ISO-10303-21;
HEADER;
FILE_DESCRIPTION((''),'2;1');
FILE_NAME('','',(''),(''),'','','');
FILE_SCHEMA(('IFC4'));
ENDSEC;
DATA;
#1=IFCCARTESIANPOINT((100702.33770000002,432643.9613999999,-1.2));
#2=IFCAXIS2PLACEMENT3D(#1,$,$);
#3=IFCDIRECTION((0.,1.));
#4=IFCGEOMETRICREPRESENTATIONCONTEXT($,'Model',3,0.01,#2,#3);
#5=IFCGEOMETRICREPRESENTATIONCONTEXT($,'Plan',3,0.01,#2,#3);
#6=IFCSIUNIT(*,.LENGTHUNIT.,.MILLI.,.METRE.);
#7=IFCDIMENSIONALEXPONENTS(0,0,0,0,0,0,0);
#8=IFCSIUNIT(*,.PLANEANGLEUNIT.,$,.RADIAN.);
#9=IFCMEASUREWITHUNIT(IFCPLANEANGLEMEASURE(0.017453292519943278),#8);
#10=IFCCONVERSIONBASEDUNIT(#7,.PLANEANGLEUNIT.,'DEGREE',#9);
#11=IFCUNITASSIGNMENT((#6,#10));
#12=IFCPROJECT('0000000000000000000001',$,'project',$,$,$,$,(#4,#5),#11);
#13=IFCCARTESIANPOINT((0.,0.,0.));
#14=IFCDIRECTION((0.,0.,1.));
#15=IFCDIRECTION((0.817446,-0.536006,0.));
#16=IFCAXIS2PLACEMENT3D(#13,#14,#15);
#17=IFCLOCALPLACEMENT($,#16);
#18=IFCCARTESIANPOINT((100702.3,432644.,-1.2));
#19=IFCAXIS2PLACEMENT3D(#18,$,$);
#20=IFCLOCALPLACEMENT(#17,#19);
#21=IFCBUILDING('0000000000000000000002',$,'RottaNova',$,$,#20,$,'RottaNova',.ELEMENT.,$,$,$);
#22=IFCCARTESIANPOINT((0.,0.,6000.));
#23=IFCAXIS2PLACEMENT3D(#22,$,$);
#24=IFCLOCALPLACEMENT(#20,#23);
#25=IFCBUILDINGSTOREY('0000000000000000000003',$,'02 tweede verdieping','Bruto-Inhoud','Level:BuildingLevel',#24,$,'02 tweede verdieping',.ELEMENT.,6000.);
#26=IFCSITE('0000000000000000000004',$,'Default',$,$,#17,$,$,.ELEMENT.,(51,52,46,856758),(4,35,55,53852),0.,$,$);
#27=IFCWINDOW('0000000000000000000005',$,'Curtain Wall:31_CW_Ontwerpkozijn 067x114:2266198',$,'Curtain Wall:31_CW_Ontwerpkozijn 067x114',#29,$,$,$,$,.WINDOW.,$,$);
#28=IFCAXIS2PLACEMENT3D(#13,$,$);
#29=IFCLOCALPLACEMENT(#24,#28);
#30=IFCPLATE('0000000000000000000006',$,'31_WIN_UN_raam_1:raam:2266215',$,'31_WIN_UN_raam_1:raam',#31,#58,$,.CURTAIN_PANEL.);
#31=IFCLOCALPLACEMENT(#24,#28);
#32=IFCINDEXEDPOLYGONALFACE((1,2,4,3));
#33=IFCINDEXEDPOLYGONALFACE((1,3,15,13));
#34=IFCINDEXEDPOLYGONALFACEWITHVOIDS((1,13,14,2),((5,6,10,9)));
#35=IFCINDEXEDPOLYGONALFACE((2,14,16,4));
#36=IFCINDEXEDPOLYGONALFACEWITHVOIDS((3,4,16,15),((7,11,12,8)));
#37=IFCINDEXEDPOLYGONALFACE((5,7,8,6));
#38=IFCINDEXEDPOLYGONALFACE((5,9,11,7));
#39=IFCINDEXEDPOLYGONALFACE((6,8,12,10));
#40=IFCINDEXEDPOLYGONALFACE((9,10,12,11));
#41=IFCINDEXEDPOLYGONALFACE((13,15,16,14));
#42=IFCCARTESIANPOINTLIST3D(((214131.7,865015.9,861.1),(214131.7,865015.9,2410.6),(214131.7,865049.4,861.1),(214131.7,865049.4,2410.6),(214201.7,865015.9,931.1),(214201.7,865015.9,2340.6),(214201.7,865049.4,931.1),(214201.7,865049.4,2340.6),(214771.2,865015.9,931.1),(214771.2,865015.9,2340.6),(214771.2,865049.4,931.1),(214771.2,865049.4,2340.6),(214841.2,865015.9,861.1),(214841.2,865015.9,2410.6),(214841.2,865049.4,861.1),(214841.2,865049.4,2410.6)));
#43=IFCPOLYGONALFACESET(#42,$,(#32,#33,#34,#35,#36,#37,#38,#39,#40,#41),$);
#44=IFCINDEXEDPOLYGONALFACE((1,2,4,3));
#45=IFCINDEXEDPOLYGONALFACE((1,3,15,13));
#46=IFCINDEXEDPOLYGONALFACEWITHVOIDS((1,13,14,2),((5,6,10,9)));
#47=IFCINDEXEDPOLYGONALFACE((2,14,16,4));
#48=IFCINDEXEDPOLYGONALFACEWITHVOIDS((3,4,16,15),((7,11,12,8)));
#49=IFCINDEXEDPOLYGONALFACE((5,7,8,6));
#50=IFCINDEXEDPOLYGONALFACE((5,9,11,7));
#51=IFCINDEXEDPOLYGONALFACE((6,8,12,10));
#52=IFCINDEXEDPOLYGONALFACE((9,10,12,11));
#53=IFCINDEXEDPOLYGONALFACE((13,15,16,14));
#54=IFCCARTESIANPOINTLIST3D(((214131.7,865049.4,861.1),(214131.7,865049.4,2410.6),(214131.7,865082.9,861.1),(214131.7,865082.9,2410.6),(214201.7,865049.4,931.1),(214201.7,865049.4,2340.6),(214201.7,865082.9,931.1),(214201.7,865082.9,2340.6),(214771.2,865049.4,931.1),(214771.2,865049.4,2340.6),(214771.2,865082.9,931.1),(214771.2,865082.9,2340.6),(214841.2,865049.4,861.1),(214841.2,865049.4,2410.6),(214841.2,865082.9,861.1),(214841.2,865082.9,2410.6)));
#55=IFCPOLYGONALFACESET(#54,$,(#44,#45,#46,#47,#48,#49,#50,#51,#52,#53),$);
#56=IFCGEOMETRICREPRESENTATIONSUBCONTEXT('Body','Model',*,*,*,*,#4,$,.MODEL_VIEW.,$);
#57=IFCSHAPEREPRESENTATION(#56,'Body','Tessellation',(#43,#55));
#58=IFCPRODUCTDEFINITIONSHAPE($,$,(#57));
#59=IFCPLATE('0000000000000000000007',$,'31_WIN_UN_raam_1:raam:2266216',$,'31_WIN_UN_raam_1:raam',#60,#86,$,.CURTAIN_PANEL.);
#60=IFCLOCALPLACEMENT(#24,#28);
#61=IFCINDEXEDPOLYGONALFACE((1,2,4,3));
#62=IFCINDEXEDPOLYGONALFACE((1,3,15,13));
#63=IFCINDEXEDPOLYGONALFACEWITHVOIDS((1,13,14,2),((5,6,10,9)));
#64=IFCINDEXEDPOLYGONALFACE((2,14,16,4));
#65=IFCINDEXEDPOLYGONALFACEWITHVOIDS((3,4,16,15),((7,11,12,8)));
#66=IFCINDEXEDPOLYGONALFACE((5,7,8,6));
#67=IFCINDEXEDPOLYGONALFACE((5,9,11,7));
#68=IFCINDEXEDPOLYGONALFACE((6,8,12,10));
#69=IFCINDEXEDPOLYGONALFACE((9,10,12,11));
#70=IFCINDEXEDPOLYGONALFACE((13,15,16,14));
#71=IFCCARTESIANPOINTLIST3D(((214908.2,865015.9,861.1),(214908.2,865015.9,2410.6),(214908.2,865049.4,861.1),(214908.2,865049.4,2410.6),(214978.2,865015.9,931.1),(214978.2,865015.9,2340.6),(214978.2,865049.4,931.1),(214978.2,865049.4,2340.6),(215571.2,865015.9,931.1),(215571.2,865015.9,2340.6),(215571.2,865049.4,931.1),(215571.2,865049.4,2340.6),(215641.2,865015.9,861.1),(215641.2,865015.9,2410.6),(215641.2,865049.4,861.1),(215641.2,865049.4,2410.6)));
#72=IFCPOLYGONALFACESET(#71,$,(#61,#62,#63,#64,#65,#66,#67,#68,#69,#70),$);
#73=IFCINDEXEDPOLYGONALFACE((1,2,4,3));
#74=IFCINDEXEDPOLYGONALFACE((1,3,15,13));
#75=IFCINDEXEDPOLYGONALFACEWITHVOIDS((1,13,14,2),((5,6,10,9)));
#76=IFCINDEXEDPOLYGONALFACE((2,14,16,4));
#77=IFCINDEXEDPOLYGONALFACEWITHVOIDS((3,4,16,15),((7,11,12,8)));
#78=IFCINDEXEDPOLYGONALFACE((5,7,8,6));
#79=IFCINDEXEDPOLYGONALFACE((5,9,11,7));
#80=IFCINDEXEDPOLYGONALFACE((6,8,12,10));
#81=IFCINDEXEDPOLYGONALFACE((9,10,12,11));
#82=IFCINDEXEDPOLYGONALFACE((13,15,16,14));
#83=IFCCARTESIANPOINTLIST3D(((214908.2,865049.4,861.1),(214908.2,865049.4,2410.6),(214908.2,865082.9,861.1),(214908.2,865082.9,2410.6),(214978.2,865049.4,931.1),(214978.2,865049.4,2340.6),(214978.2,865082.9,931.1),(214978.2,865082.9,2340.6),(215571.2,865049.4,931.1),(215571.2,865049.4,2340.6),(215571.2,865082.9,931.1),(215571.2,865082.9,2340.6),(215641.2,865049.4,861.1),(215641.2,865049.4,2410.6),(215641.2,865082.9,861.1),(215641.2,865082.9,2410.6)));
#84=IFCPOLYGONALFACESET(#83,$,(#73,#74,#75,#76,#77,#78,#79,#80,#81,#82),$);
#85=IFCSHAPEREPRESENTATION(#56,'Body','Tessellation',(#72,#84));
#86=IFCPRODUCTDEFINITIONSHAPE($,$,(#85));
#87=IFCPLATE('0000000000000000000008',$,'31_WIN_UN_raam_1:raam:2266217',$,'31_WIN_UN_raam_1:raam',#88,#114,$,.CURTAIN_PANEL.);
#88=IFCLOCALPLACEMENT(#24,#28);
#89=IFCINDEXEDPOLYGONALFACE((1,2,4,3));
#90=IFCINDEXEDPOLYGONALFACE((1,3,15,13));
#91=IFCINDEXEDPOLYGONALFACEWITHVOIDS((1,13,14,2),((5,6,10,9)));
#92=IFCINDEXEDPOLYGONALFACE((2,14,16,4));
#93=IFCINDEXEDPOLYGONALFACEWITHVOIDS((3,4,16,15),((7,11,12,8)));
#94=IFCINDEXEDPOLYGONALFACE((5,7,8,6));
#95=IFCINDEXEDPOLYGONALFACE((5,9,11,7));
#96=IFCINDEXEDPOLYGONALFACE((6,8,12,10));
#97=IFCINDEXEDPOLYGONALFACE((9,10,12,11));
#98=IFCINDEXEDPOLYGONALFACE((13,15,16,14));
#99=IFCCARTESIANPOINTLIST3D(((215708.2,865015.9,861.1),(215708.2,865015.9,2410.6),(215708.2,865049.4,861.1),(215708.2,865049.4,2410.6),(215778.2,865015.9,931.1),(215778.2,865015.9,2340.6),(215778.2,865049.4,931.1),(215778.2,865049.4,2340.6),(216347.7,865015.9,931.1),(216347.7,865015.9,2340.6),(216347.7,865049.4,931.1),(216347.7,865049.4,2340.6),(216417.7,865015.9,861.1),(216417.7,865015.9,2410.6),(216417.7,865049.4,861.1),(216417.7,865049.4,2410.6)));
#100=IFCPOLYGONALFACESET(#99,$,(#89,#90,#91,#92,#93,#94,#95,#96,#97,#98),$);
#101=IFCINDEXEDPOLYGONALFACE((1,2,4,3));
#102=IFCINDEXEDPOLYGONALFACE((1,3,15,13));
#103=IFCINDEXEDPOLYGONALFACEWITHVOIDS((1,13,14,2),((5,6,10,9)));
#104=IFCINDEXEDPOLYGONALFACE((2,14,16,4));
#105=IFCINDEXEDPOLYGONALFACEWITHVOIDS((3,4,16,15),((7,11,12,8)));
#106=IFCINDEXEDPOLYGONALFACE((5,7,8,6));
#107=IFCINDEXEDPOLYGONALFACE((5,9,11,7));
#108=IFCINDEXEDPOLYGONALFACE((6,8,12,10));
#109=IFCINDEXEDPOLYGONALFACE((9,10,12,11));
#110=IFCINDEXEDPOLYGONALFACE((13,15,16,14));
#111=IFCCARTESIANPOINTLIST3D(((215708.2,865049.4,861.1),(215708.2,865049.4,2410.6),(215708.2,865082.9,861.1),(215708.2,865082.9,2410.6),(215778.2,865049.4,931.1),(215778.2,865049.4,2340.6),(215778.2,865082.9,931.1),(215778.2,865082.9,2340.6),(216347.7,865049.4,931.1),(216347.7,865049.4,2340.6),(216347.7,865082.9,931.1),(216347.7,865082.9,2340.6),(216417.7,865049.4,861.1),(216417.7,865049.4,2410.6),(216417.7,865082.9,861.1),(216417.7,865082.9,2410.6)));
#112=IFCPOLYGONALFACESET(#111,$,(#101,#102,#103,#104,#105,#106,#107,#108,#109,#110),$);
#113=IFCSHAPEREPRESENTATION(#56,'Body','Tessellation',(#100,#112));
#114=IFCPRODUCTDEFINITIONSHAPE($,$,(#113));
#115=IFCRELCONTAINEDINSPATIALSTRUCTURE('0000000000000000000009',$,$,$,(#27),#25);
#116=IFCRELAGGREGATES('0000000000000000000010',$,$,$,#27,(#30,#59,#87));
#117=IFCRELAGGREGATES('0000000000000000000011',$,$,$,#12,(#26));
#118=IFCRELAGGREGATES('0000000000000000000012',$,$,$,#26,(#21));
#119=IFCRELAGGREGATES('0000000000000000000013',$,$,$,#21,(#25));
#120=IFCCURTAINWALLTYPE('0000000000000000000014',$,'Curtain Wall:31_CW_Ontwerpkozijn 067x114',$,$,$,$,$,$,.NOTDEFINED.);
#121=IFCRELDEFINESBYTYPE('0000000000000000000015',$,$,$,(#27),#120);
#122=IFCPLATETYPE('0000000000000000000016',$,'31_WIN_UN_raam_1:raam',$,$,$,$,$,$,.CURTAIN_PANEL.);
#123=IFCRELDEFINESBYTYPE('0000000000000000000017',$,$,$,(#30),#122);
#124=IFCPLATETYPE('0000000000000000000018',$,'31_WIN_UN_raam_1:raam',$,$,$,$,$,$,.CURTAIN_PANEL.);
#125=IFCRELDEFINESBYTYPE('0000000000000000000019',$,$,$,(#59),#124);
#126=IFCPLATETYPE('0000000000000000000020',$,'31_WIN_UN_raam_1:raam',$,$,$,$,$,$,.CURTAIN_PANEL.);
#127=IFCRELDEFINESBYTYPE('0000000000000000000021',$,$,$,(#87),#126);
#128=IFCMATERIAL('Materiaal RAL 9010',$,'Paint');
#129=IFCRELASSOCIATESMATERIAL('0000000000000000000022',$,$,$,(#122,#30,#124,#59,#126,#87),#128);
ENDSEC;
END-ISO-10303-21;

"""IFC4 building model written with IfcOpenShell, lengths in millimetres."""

from ifc_helpers import new_model, entity, si_unit, converted_unit, direction, frame, place, context, subcontext, project, spatial, indexed_curve, outline, extrude, source, transform, mapped, material, type_object, type_shapes, element, aggregate, save


model = new_model("IFC4")

# Units and contexts
model_context = context("Model", 3, precision=0.01, world=frame((100702.33770000002, 432643.9613999999, -1.2)), true_north=direction((0.0, 1.0)))
plan_context = context("Plan", 3, precision=0.01, world=frame((100702.33770000002, 432643.9613999999, -1.2)), true_north=direction((0.0, 1.0)))
body_context = subcontext(model_context, "Body", "Model", "MODEL_VIEW")
ifc_project = project(units=[si_unit("LENGTHUNIT", "METRE", prefix="MILLI"), converted_unit("PLANEANGLEUNIT", "DEGREE", entity("IfcPlaneAngleMeasure", 0.017453292519943278), si_unit("PLANEANGLEUNIT", "RADIAN"), dimensions=[0, 0, 0, 0, 0, 0, 0])], contexts=[model_context, plan_context])

# Site, building, storey
site_placement = place(None, frame((0.0, 0.0, 0.0), z_axis=(0.0, 0.0, 1.0), x_axis=(0.817446, -0.536006, 0.0)))
site = spatial("IfcSite", under=ifc_project, at=site_placement, Name="Default", CompositionType="ELEMENT", RefLatitude=(51, 52, 46, 856758), RefLongitude=(4, 35, 55, 53852), RefElevation=0.0)
building_placement = place(site_placement, frame((100702.3, 432644.0, -1.2)))
building = spatial("IfcBuilding", under=site, at=building_placement, Name="RottaNova", LongName="RottaNova", CompositionType="ELEMENT")
storey_placement = place(building_placement, frame((0.0, 0.0, 6000.0)))
storey = spatial("IfcBuildingStorey", under=building, at=storey_placement, Name="02 tweede verdieping", Description="Bruto-Inhoud", ObjectType="Level:BuildingLevel", LongName="02 tweede verdieping", CompositionType="ELEMENT", Elevation=6000.0)

# Window, plates
curtain_wall_type = type_object("IfcCurtainWallType", Name="Curtain Wall:31_CW_Ontwerpkozijn 067x114", PredefinedType="NOTDEFINED")
window_1_placement = place(storey_placement, frame((0.0, 0.0, -6000.0)))
window_1 = element("IfcWindow", 1, at=window_1_placement, inside=storey, type_object=curtain_wall_type, Name="Curtain Wall:31_CW_Ontwerpkozijn 067x114:2266198", ObjectType="Curtain Wall:31_CW_Ontwerpkozijn 067x114", PredefinedType="WINDOW")
ifc_material_1 = material(Name="Materiaal RAL 9010", Category="Paint")
plate_type_1 = type_object("IfcPlateType", Name="31_WIN_UN_raam_1:raam", PredefinedType="CURTAIN_PANEL", material=ifc_material_1)
shared_shape_1 = source(frame((100702.3, 432644.0, -1.2)), body_context, "Body", "SweptSolid", [
    extrude(outline(indexed_curve([(-354.7, -774.7), (354.7, -774.7), (354.7, 774.7), (-354.7, 774.7), (-354.7, -774.7)], self_intersect=False), holes=[indexed_curve([(-284.7, 704.7), (284.7, 704.7), (284.7, -704.8), (-284.7, -704.8), (-284.7, 704.7)], self_intersect=False)]), frame((0.0, -92.0, 774.8), z_axis=(0.0, 1.0, 0.0), x_axis=(1.0, 0.0, 0.0)), (0.0, 0.0, 1.0), 33.5),
    extrude(outline(indexed_curve([(-354.7, -774.7), (354.7, -774.7), (354.7, 774.7), (-354.7, 774.7), (-354.7, -774.7)], self_intersect=False), holes=[indexed_curve([(-284.7, 704.7), (284.7, 704.7), (284.7, -704.8), (-284.7, -704.8), (-284.7, 704.7)], self_intersect=False)]), frame((0.0, -58.5, 774.8), z_axis=(0.0, 1.0, 0.0), x_axis=(1.0, 0.0, 0.0)), (0.0, 0.0, 1.0), 33.5),
])
type_shapes(plate_type_1, [shared_shape_1])
plate_1_placement = place(window_1_placement, frame((13081.8, -180.0, 6863.5)))
plate_1 = element("IfcPlate", 2, at=plate_1_placement, type_object=plate_type_1, material=ifc_material_1, Name="31_WIN_UN_raam_1:raam:2266215", ObjectType="31_WIN_UN_raam_1:raam", PredefinedType="CURTAIN_PANEL", context=body_context, shape_type="MappedRepresentation", body=[
    mapped(shared_shape_1, transform((100702.3, 432644.0, -1.2), scale=1.0)),
])
plate_type_2 = type_object("IfcPlateType", Name="31_WIN_UN_raam_1:raam", PredefinedType="CURTAIN_PANEL", material=ifc_material_1)
shared_shape_2 = source(frame((100702.3, 432644.0, -1.2)), body_context, "Body", "SweptSolid", [
    extrude(outline(indexed_curve([(-366.5, -774.8), (366.5, -774.8), (366.5, 774.8), (-366.5, 774.8), (-366.5, -774.8)], self_intersect=False), holes=[indexed_curve([(-296.5, 704.8), (296.5, 704.8), (296.5, -704.8), (-296.5, -704.8), (-296.5, 704.8)], self_intersect=False)]), frame((0.0, -92.0, 774.8), z_axis=(0.0, 1.0, 0.0), x_axis=(1.0, 0.0, 0.0)), (0.0, 0.0, 1.0), 33.5),
    extrude(outline(indexed_curve([(-366.5, -774.8), (366.5, -774.8), (366.5, 774.8), (-366.5, 774.8), (-366.5, -774.8)], self_intersect=False), holes=[indexed_curve([(-296.5, 704.7), (296.5, 704.7), (296.5, -704.8), (-296.5, -704.8), (-296.5, 704.7)], self_intersect=False)]), frame((0.0, -58.5, 774.8), z_axis=(0.0, 1.0, 0.0), x_axis=(1.0, 0.0, 0.0)), (0.0, 0.0, 1.0), 33.5),
])
type_shapes(plate_type_2, [shared_shape_2])
plate_2_placement = place(window_1_placement, frame((13870.0, -180.0, 6863.5)))
plate_2 = element("IfcPlate", 3, at=plate_2_placement, type_object=plate_type_2, material=ifc_material_1, Name="31_WIN_UN_raam_1:raam:2266216", ObjectType="31_WIN_UN_raam_1:raam", PredefinedType="CURTAIN_PANEL", context=body_context, shape_type="MappedRepresentation", body=[
    mapped(shared_shape_2, transform((100702.3, 432644.0, -1.2), scale=1.0)),
])
plate_type_3 = type_object("IfcPlateType", Name="31_WIN_UN_raam_1:raam", PredefinedType="CURTAIN_PANEL", material=ifc_material_1)
shared_shape_3 = source(frame((100702.3, 432644.0, -1.2)), body_context, "Body", "SweptSolid", [
    extrude(outline(indexed_curve([(-354.8, -774.7), (354.8, -774.7), (354.8, 774.7), (-354.8, 774.7), (-354.8, -774.7)], self_intersect=False), holes=[indexed_curve([(-284.8, 704.7), (284.8, 704.7), (284.8, -704.8), (-284.8, -704.8), (-284.8, 704.7)], self_intersect=False)]), frame((0.0, -92.0, 774.8), z_axis=(0.0, 1.0, 0.0), x_axis=(1.0, 0.0, 0.0)), (0.0, 0.0, 1.0), 33.5),
    extrude(outline(indexed_curve([(-354.8, -774.7), (354.8, -774.7), (354.8, 774.7), (-354.8, 774.7), (-354.8, -774.7)], self_intersect=False), holes=[indexed_curve([(-284.8, 704.7), (284.8, 704.7), (284.8, -704.8), (-284.8, -704.8), (-284.8, 704.7)], self_intersect=False)]), frame((0.0, -58.5, 774.8), z_axis=(0.0, 1.0, 0.0), x_axis=(1.0, 0.0, 0.0)), (0.0, 0.0, 1.0), 33.5),
])
type_shapes(plate_type_3, [shared_shape_3])
plate_3_placement = place(window_1_placement, frame((14658.3, -180.0, 6863.5)))
plate_3 = element("IfcPlate", 4, at=plate_3_placement, type_object=plate_type_3, material=ifc_material_1, Name="31_WIN_UN_raam_1:raam:2266217", ObjectType="31_WIN_UN_raam_1:raam", PredefinedType="CURTAIN_PANEL", context=body_context, shape_type="MappedRepresentation", body=[
    mapped(shared_shape_3, transform((100702.3, 432644.0, -1.2), scale=1.0)),
])
aggregate(window_1, [plate_1, plate_2, plate_3])

save(model, "model.ifc")
